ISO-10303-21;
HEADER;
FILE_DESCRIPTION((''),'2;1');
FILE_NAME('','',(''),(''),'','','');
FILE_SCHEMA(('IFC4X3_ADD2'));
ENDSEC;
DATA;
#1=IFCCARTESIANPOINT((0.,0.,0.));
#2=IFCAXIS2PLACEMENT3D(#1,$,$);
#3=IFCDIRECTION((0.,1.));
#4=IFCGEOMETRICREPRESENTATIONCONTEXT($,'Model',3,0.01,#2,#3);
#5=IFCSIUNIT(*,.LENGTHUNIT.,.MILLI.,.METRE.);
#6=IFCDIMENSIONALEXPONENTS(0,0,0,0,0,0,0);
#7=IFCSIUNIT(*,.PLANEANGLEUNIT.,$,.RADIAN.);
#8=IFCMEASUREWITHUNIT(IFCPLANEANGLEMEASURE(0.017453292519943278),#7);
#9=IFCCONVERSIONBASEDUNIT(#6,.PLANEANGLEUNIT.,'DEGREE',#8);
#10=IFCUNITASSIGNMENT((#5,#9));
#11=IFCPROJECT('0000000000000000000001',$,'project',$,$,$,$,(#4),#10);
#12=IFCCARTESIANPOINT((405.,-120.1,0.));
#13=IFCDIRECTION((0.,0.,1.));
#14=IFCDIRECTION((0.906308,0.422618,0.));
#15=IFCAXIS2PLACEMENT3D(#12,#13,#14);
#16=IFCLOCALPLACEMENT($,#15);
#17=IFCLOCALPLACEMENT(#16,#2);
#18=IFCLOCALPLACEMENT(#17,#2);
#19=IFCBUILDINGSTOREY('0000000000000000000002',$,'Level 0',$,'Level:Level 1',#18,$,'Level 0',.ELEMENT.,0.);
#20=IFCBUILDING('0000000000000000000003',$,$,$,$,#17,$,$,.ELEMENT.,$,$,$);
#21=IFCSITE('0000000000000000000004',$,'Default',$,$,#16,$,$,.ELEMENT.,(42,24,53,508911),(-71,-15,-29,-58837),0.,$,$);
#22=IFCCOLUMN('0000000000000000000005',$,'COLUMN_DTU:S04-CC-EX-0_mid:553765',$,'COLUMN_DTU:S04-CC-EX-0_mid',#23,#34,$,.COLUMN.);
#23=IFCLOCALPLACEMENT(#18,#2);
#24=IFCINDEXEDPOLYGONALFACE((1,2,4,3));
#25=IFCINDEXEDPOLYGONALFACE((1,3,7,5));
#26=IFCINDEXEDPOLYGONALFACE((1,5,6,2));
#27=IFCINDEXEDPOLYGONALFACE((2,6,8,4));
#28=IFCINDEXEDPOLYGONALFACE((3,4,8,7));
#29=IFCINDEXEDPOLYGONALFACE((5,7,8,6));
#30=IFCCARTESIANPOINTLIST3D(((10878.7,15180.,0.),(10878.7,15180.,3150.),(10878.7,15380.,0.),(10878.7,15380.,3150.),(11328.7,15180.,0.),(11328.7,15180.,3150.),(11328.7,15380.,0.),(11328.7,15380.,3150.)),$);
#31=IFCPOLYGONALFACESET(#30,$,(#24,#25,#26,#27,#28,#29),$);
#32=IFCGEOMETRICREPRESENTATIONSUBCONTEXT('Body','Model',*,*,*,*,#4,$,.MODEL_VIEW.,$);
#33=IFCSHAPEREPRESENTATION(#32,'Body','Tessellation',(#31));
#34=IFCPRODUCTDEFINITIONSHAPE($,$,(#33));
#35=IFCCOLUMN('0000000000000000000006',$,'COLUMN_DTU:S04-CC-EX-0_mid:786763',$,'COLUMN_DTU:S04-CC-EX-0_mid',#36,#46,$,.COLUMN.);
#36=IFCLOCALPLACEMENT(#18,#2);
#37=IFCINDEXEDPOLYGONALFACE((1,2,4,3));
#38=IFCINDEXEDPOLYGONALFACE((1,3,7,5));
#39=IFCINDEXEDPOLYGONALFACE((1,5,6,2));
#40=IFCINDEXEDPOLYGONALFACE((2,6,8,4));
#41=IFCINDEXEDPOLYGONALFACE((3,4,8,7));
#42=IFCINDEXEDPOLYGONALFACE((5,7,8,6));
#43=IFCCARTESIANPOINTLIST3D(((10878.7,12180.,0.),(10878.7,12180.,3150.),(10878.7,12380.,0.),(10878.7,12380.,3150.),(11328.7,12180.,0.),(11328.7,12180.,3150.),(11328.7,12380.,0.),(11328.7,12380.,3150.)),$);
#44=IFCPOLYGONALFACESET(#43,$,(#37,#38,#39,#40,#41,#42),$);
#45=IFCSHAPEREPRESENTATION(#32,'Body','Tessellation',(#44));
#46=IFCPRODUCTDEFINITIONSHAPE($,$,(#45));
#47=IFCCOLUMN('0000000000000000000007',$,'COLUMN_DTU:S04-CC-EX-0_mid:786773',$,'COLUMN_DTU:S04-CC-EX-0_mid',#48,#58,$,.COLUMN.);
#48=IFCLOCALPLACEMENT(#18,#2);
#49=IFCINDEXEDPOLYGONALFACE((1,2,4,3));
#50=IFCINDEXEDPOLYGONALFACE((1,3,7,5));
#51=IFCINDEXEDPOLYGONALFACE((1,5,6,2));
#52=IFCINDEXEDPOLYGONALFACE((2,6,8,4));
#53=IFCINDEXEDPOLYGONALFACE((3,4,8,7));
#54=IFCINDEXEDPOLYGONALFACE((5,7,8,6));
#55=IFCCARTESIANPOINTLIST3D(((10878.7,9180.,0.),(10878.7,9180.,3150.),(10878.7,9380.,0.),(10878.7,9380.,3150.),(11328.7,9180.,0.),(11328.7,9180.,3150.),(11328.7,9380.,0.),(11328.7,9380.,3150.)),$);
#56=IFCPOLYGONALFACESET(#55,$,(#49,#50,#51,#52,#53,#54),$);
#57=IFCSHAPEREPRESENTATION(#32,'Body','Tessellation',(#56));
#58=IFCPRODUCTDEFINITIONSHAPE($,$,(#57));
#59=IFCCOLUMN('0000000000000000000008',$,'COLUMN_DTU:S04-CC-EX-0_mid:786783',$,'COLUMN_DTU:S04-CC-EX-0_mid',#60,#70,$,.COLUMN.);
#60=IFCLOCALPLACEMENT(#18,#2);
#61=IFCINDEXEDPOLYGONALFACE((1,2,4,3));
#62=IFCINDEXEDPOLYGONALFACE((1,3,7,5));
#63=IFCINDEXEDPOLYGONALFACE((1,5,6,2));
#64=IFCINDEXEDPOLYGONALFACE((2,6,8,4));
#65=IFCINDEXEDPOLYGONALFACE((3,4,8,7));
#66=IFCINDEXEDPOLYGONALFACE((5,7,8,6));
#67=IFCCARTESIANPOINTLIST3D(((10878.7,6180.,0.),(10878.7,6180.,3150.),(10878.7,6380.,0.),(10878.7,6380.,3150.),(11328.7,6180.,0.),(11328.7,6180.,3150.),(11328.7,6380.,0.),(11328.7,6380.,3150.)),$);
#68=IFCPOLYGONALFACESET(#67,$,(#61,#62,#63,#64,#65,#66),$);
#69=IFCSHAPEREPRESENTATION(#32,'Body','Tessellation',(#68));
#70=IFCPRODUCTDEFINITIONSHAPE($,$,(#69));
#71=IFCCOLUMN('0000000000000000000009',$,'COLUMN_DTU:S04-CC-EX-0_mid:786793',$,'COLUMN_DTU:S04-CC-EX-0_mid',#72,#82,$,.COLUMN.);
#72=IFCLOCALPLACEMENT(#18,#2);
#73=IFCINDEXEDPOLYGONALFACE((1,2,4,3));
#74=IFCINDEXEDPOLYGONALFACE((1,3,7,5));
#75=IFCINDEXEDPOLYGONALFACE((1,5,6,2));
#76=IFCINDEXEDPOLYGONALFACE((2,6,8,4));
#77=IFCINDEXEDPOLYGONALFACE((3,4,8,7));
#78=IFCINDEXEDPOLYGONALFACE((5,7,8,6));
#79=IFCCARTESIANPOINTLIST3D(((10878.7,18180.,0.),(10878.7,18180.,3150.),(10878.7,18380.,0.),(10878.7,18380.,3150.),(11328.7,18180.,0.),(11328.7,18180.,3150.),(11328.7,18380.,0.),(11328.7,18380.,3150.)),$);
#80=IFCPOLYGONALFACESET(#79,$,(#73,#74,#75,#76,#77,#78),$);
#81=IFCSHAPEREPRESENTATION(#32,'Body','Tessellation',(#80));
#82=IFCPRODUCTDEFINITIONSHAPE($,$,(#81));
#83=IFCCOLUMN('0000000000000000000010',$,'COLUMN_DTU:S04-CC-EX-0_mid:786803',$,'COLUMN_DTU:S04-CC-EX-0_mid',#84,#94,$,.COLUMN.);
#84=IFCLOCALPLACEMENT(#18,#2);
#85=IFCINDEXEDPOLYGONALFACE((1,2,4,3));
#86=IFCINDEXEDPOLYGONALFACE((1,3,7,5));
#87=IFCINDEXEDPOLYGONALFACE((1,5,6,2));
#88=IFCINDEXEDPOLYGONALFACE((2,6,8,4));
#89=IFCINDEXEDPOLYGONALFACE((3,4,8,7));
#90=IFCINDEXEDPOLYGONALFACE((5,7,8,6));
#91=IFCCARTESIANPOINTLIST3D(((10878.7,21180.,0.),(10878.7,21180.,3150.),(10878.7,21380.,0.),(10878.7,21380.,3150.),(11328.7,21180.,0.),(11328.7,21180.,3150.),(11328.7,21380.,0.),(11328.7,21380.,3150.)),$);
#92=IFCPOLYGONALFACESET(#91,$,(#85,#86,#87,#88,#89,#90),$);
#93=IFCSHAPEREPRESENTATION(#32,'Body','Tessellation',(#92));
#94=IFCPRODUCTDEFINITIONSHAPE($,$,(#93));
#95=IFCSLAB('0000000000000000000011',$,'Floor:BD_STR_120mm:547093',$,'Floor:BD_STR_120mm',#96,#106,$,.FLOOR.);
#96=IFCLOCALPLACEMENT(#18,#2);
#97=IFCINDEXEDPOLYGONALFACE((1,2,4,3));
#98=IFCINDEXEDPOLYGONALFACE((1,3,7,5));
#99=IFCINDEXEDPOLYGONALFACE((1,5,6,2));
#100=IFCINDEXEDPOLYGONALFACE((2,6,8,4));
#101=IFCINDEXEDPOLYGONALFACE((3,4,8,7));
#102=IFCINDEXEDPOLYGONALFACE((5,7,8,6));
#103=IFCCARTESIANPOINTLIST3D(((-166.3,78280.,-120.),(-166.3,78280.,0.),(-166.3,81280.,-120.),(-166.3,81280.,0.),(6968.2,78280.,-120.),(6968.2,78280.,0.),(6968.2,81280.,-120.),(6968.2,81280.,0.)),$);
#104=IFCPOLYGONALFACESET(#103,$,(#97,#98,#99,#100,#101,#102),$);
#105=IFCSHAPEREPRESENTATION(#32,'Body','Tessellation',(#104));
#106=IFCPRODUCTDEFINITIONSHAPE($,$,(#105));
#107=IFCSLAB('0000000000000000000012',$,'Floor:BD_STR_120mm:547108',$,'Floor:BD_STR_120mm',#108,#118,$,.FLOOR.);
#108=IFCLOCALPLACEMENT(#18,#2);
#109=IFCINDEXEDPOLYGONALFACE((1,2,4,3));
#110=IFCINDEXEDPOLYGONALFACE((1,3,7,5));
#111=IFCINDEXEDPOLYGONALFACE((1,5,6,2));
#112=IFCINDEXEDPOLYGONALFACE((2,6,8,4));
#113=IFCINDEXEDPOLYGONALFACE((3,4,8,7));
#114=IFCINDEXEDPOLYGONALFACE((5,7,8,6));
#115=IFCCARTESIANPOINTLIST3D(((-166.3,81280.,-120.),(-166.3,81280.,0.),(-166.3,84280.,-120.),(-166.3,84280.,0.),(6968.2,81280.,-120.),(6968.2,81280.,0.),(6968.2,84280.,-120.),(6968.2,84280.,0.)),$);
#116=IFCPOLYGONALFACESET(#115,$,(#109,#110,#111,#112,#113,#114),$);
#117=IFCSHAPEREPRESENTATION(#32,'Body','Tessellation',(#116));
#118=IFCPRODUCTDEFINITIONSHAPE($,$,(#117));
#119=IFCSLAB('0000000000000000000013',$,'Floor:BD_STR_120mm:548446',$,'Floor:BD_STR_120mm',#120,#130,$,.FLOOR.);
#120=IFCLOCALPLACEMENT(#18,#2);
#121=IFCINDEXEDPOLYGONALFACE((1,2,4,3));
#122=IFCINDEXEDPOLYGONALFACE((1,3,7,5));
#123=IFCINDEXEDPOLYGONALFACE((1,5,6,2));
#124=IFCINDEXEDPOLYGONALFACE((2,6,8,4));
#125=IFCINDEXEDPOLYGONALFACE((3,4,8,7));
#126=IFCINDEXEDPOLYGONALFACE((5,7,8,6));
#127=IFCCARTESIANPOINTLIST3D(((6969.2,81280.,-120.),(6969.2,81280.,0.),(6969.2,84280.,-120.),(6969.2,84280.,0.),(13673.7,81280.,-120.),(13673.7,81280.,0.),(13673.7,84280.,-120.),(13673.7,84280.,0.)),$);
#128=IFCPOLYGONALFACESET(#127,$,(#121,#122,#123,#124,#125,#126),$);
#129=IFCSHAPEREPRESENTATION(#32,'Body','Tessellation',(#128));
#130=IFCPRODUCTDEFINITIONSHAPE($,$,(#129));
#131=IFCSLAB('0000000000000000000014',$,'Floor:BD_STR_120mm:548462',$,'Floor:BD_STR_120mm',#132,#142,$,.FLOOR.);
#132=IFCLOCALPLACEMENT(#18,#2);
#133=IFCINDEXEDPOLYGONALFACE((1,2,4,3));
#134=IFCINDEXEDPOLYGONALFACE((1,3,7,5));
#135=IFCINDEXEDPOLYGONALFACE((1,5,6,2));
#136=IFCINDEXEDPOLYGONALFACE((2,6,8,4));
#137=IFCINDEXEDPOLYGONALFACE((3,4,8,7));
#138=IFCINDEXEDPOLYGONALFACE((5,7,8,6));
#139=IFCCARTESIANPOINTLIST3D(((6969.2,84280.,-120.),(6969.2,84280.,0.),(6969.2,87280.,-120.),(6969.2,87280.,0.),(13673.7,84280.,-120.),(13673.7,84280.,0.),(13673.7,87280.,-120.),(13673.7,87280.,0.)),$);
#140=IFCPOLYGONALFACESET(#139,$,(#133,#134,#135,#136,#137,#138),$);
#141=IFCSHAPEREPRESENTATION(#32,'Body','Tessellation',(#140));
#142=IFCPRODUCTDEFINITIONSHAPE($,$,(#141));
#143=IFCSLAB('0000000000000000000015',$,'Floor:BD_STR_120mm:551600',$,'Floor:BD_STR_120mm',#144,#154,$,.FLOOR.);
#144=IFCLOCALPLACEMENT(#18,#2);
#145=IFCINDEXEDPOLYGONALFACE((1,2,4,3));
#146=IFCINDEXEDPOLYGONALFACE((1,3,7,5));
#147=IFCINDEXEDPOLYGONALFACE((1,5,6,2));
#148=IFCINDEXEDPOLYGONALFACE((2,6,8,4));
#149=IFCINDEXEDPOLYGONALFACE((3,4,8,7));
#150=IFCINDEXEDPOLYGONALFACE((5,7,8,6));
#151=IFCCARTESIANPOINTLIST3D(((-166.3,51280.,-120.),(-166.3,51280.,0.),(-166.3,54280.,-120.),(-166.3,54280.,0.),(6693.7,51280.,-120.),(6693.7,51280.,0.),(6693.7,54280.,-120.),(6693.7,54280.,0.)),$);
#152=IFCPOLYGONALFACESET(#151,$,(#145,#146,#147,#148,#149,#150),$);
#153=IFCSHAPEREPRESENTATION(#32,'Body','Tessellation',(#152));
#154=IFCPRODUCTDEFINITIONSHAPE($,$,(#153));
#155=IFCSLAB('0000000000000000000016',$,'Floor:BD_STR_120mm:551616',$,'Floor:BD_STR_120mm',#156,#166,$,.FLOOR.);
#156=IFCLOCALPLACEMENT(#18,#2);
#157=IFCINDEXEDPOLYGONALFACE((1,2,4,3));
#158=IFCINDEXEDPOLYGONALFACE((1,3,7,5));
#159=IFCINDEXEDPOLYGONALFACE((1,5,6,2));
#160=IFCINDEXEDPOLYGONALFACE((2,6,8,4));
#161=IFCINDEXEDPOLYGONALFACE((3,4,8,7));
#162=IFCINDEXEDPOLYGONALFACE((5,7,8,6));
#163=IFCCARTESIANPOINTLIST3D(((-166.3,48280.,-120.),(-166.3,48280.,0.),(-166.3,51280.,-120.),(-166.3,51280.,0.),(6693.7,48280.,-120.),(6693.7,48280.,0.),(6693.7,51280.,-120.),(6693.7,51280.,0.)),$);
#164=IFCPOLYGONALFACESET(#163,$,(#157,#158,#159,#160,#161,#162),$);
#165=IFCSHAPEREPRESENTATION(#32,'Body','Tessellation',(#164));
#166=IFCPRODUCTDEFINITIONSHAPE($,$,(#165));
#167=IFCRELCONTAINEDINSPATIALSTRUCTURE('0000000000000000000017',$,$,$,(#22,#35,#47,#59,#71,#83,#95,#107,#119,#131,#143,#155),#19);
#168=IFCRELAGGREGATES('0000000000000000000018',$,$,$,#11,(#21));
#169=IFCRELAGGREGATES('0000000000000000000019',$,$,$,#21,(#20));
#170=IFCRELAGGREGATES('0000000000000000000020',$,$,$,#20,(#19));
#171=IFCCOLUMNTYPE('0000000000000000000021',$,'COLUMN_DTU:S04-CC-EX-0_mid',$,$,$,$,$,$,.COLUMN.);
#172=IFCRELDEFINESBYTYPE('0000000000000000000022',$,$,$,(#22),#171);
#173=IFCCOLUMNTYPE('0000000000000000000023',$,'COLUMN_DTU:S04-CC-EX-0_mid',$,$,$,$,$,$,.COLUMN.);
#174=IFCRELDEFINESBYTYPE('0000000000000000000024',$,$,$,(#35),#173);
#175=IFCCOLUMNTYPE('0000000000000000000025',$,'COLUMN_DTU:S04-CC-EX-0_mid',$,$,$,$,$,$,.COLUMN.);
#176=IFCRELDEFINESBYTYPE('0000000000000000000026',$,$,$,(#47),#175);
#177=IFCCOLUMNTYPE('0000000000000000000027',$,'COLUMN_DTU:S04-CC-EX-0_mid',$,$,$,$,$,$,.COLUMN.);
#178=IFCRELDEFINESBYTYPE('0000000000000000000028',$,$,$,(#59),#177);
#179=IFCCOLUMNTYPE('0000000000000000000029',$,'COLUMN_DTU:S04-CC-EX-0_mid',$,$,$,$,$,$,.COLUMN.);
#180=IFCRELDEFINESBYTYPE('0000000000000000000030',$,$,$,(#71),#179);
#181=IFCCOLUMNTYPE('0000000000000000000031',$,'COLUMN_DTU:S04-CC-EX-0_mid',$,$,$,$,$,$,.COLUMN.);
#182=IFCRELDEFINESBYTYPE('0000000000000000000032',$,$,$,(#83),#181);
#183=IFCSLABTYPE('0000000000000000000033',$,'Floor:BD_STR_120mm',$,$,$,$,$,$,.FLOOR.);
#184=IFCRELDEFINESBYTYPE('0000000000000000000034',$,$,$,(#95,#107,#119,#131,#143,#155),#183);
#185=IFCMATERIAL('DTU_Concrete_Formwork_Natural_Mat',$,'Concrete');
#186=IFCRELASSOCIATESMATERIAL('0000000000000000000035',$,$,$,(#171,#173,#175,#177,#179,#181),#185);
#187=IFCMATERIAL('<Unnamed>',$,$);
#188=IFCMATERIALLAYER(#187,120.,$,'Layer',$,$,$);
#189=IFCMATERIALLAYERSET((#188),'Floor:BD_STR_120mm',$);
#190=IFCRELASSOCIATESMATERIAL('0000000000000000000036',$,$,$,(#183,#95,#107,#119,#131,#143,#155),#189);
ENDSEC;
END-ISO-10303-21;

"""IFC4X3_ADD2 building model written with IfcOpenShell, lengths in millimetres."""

from ifc_helpers import new_model, entity, si_unit, converted_unit, direction, frame, frame_2d, origin, origin_2d_with_axis, place, context, subcontext, project, spatial, rectangle, extrude, source, transform, mapped, material, layer, layer_set, layer_usage, material_profile, profile_set, type_object, type_shapes, element, save


model = new_model("IFC4X3_ADD2")

# Units and contexts
model_context = context("Model", 3, precision=0.01, world=origin(), true_north=direction((0.0, 1.0)))
body_context = subcontext(model_context, "Body", "Model", "MODEL_VIEW")
ifc_project = project(units=[si_unit("LENGTHUNIT", "METRE", prefix="MILLI"), converted_unit("PLANEANGLEUNIT", "DEGREE", entity("IfcPlaneAngleMeasure", 0.017453292519943278), si_unit("PLANEANGLEUNIT", "RADIAN"), dimensions=[0, 0, 0, 0, 0, 0, 0])], contexts=[model_context])

# Site, building, storey
site_placement = place(None, frame((405.0, -120.1, 0.0), z_axis=(0.0, 0.0, 1.0), x_axis=(0.906308, 0.422618, 0.0)))
site = spatial("IfcSite", under=ifc_project, at=site_placement, Name="Default", CompositionType="ELEMENT", RefLatitude=(42, 24, 53, 508911), RefLongitude=(-71, -15, -29, -58837), RefElevation=0.0)
building_placement = place(site_placement, origin())
building = spatial("IfcBuilding", under=site, at=building_placement, CompositionType="ELEMENT")
storey_placement = place(building_placement, origin())
storey = spatial("IfcBuildingStorey", under=building, at=storey_placement, Name="Level 0", ObjectType="Level:Level 1", LongName="Level 0", CompositionType="ELEMENT", Elevation=0.0)

# Columns
ifc_material_1 = material(Name="DTU_Concrete_Formwork_Natural_Mat", Category="Concrete")
ifc_material_profile = material_profile(ifc_material_1, rectangle(XDim=200.0, YDim=450.0, at=frame_2d((0.0, 0.0), x_axis=(1.0, 0.0))), Name="S04-CC-EX-0_mid")
ifc_profile_set = profile_set([ifc_material_profile], Name="S04-CC-EX-0_mid")
column_type_1 = type_object("IfcColumnType", Name="COLUMN_DTU:S04-CC-EX-0_mid", PredefinedType="COLUMN", material=ifc_profile_set)
shared_shape_1 = source(origin(), body_context, "Body", "SweptSolid", [
    extrude(rectangle(XDim=200.0, YDim=450.0, at=frame_2d((0.0, 0.0), x_axis=(1.0, 0.0))), frame((11103.7, 15280.0, 0.0), z_axis=(0.0, 0.0, 1.0), x_axis=(0.0, 1.0, 0.0)), (0.0, 0.0, 1.0), 3150.0),
])
type_shapes(column_type_1, [shared_shape_1])
column_1_placement = place(storey_placement, origin())
element("IfcColumn", 1, at=column_1_placement, inside=storey, type_object=column_type_1, Name="COLUMN_DTU:S04-CC-EX-0_mid:553765", ObjectType="COLUMN_DTU:S04-CC-EX-0_mid", PredefinedType="COLUMN", context=body_context, shape_type="MappedRepresentation", body=[
    mapped(shared_shape_1, transform((0.0, 0.0, 0.0), scale=1.0)),
])
column_type_2 = type_object("IfcColumnType", Name="COLUMN_DTU:S04-CC-EX-0_mid", PredefinedType="COLUMN", material=ifc_profile_set)
shared_shape_2 = source(origin(), body_context, "Body", "SweptSolid", [
    extrude(rectangle(XDim=200.0, YDim=450.0, at=frame_2d((0.0, 0.0), x_axis=(1.0, 0.0))), frame((11103.7, 12280.0, 0.0), z_axis=(0.0, 0.0, 1.0), x_axis=(0.0, 1.0, 0.0)), (0.0, 0.0, 1.0), 3150.0),
])
type_shapes(column_type_2, [shared_shape_2])
column_2_placement = place(storey_placement, origin())
element("IfcColumn", 2, at=column_2_placement, inside=storey, type_object=column_type_2, Name="COLUMN_DTU:S04-CC-EX-0_mid:786763", ObjectType="COLUMN_DTU:S04-CC-EX-0_mid", PredefinedType="COLUMN", context=body_context, shape_type="MappedRepresentation", body=[
    mapped(shared_shape_2, transform((0.0, 0.0, 0.0), scale=1.0)),
])
column_type_3 = type_object("IfcColumnType", Name="COLUMN_DTU:S04-CC-EX-0_mid", PredefinedType="COLUMN", material=ifc_profile_set)
shared_shape_3 = source(origin(), body_context, "Body", "SweptSolid", [
    extrude(rectangle(XDim=200.0, YDim=450.0, at=frame_2d((0.0, 0.0), x_axis=(1.0, 0.0))), frame((11103.7, 9280.0, 0.0), z_axis=(0.0, 0.0, 1.0), x_axis=(0.0, 1.0, 0.0)), (0.0, 0.0, 1.0), 3150.0),
])
type_shapes(column_type_3, [shared_shape_3])
column_3_placement = place(storey_placement, origin())
element("IfcColumn", 3, at=column_3_placement, inside=storey, type_object=column_type_3, Name="COLUMN_DTU:S04-CC-EX-0_mid:786773", ObjectType="COLUMN_DTU:S04-CC-EX-0_mid", PredefinedType="COLUMN", context=body_context, shape_type="MappedRepresentation", body=[
    mapped(shared_shape_3, transform((0.0, 0.0, 0.0), scale=1.0)),
])
column_type_4 = type_object("IfcColumnType", Name="COLUMN_DTU:S04-CC-EX-0_mid", PredefinedType="COLUMN", material=ifc_profile_set)
shared_shape_4 = source(origin(), body_context, "Body", "SweptSolid", [
    extrude(rectangle(XDim=200.0, YDim=450.0, at=frame_2d((0.0, 0.0), x_axis=(1.0, 0.0))), frame((11103.7, 6280.0, 0.0), z_axis=(0.0, 0.0, 1.0), x_axis=(0.0, 1.0, 0.0)), (0.0, 0.0, 1.0), 3150.0),
])
type_shapes(column_type_4, [shared_shape_4])
column_4_placement = place(storey_placement, origin())
element("IfcColumn", 4, at=column_4_placement, inside=storey, type_object=column_type_4, Name="COLUMN_DTU:S04-CC-EX-0_mid:786783", ObjectType="COLUMN_DTU:S04-CC-EX-0_mid", PredefinedType="COLUMN", context=body_context, shape_type="MappedRepresentation", body=[
    mapped(shared_shape_4, transform((0.0, 0.0, 0.0), scale=1.0)),
])
column_type_5 = type_object("IfcColumnType", Name="COLUMN_DTU:S04-CC-EX-0_mid", PredefinedType="COLUMN", material=ifc_profile_set)
shared_shape_5 = source(origin(), body_context, "Body", "SweptSolid", [
    extrude(rectangle(XDim=200.0, YDim=450.0, at=frame_2d((0.0, 0.0), x_axis=(1.0, 0.0))), frame((11103.7, 18280.0, 0.0), z_axis=(0.0, 0.0, 1.0), x_axis=(0.0, 1.0, 0.0)), (0.0, 0.0, 1.0), 3150.0),
])
type_shapes(column_type_5, [shared_shape_5])
column_5_placement = place(storey_placement, origin())
element("IfcColumn", 5, at=column_5_placement, inside=storey, type_object=column_type_5, Name="COLUMN_DTU:S04-CC-EX-0_mid:786793", ObjectType="COLUMN_DTU:S04-CC-EX-0_mid", PredefinedType="COLUMN", context=body_context, shape_type="MappedRepresentation", body=[
    mapped(shared_shape_5, transform((0.0, 0.0, 0.0), scale=1.0)),
])
column_type_6 = type_object("IfcColumnType", Name="COLUMN_DTU:S04-CC-EX-0_mid", PredefinedType="COLUMN", material=ifc_profile_set)
shared_shape_6 = source(origin(), body_context, "Body", "SweptSolid", [
    extrude(rectangle(XDim=200.0, YDim=450.0, at=frame_2d((0.0, 0.0), x_axis=(1.0, 0.0))), frame((11103.7, 21280.0, 0.0), z_axis=(0.0, 0.0, 1.0), x_axis=(0.0, 1.0, 0.0)), (0.0, 0.0, 1.0), 3150.0),
])
type_shapes(column_type_6, [shared_shape_6])
column_6_placement = place(storey_placement, origin())
element("IfcColumn", 6, at=column_6_placement, inside=storey, type_object=column_type_6, Name="COLUMN_DTU:S04-CC-EX-0_mid:786803", ObjectType="COLUMN_DTU:S04-CC-EX-0_mid", PredefinedType="COLUMN", context=body_context, shape_type="MappedRepresentation", body=[
    mapped(shared_shape_6, transform((0.0, 0.0, 0.0), scale=1.0)),
])

# Slabs
ifc_material_2 = material(Name="<Unnamed>")
ifc_layer_1 = layer(ifc_material_2, 120.0, Name="Layer")
ifc_layer_set_1 = layer_set([ifc_layer_1], Name="Floor:BD_STR_120mm")
ifc_layer_usage_1 = layer_usage(ifc_layer_set_1, "AXIS3", "POSITIVE", 0.0)
slab_type_1 = type_object("IfcSlabType", Name="Floor:BD_STR_120mm", PredefinedType="FLOOR", material=ifc_layer_set_1)
slab_1_placement = place(storey_placement, origin())
element("IfcSlab", 7, at=slab_1_placement, inside=storey, type_object=slab_type_1, material=ifc_layer_usage_1, Name="Floor:BD_STR_120mm:547093", ObjectType="Floor:BD_STR_120mm", PredefinedType="FLOOR", context=body_context, shape_type="SweptSolid", body=[
    extrude(rectangle(XDim=3000.0, YDim=7134.5, at=frame_2d((0.0, 0.0), x_axis=(1.0, 0.0))), frame((3401.0, 79780.0, 0.0), z_axis=(0.0, 0.0, -1.0), x_axis=(0.0, 1.0, 0.0)), (0.0, 0.0, 1.0), 120.0),
])
ifc_layer_usage_2 = layer_usage(ifc_layer_set_1, "AXIS3", "POSITIVE", 0.0)
slab_2_placement = place(storey_placement, origin())
element("IfcSlab", 8, at=slab_2_placement, inside=storey, type_object=slab_type_1, material=ifc_layer_usage_2, Name="Floor:BD_STR_120mm:547108", ObjectType="Floor:BD_STR_120mm", PredefinedType="FLOOR", context=body_context, shape_type="SweptSolid", body=[
    extrude(rectangle(XDim=3000.0, YDim=7134.5, at=frame_2d((0.0, 0.0), x_axis=(1.0, 0.0))), frame((3401.0, 82780.0, 0.0), z_axis=(0.0, 0.0, -1.0), x_axis=(0.0, 1.0, 0.0)), (0.0, 0.0, 1.0), 120.0),
])
ifc_layer_usage_3 = layer_usage(ifc_layer_set_1, "AXIS3", "POSITIVE", 0.0)
slab_3_placement = place(storey_placement, origin())
element("IfcSlab", 9, at=slab_3_placement, inside=storey, type_object=slab_type_1, material=ifc_layer_usage_3, Name="Floor:BD_STR_120mm:548446", ObjectType="Floor:BD_STR_120mm", PredefinedType="FLOOR", context=body_context, shape_type="SweptSolid", body=[
    extrude(rectangle(XDim=3000.0, YDim=6704.5, at=frame_2d((0.0, 0.0), x_axis=(1.0, 0.0))), frame((10321.5, 82780.0, 0.0), z_axis=(0.0, 0.0, -1.0), x_axis=(0.0, 1.0, 0.0)), (0.0, 0.0, 1.0), 120.0),
])
ifc_layer_usage_4 = layer_usage(ifc_layer_set_1, "AXIS3", "POSITIVE", 0.0)
slab_4_placement = place(storey_placement, origin())
element("IfcSlab", 10, at=slab_4_placement, inside=storey, type_object=slab_type_1, material=ifc_layer_usage_4, Name="Floor:BD_STR_120mm:548462", ObjectType="Floor:BD_STR_120mm", PredefinedType="FLOOR", context=body_context, shape_type="SweptSolid", body=[
    extrude(rectangle(XDim=3000.0, YDim=6704.5, at=frame_2d((0.0, 0.0), x_axis=(1.0, 0.0))), frame((10321.5, 85780.0, 0.0), z_axis=(0.0, 0.0, -1.0), x_axis=(0.0, 1.0, 0.0)), (0.0, 0.0, 1.0), 120.0),
])
ifc_layer_usage_5 = layer_usage(ifc_layer_set_1, "AXIS3", "POSITIVE", 0.0)
slab_5_placement = place(storey_placement, origin())
element("IfcSlab", 11, at=slab_5_placement, inside=storey, type_object=slab_type_1, material=ifc_layer_usage_5, Name="Floor:BD_STR_120mm:551600", ObjectType="Floor:BD_STR_120mm", PredefinedType="FLOOR", context=body_context, shape_type="SweptSolid", body=[
    extrude(rectangle(XDim=3000.0, YDim=6860.0, at=origin_2d_with_axis()), frame((3263.7, 52780.0, 0.0), z_axis=(0.0, 0.0, -1.0), x_axis=(0.0, 1.0, 0.0)), (0.0, 0.0, 1.0), 120.0),
])
ifc_layer_usage_6 = layer_usage(ifc_layer_set_1, "AXIS3", "POSITIVE", 0.0)
slab_6_placement = place(storey_placement, origin())
element("IfcSlab", 12, at=slab_6_placement, inside=storey, type_object=slab_type_1, material=ifc_layer_usage_6, Name="Floor:BD_STR_120mm:551616", ObjectType="Floor:BD_STR_120mm", PredefinedType="FLOOR", context=body_context, shape_type="SweptSolid", body=[
    extrude(rectangle(XDim=3000.0, YDim=6860.0, at=frame_2d((0.0, 0.0), x_axis=(1.0, 0.0))), frame((3263.7, 49780.0, 0.0), z_axis=(0.0, 0.0, -1.0), x_axis=(0.0, 1.0, 0.0)), (0.0, 0.0, 1.0), 120.0),
])

save(model, "model.ifc")
